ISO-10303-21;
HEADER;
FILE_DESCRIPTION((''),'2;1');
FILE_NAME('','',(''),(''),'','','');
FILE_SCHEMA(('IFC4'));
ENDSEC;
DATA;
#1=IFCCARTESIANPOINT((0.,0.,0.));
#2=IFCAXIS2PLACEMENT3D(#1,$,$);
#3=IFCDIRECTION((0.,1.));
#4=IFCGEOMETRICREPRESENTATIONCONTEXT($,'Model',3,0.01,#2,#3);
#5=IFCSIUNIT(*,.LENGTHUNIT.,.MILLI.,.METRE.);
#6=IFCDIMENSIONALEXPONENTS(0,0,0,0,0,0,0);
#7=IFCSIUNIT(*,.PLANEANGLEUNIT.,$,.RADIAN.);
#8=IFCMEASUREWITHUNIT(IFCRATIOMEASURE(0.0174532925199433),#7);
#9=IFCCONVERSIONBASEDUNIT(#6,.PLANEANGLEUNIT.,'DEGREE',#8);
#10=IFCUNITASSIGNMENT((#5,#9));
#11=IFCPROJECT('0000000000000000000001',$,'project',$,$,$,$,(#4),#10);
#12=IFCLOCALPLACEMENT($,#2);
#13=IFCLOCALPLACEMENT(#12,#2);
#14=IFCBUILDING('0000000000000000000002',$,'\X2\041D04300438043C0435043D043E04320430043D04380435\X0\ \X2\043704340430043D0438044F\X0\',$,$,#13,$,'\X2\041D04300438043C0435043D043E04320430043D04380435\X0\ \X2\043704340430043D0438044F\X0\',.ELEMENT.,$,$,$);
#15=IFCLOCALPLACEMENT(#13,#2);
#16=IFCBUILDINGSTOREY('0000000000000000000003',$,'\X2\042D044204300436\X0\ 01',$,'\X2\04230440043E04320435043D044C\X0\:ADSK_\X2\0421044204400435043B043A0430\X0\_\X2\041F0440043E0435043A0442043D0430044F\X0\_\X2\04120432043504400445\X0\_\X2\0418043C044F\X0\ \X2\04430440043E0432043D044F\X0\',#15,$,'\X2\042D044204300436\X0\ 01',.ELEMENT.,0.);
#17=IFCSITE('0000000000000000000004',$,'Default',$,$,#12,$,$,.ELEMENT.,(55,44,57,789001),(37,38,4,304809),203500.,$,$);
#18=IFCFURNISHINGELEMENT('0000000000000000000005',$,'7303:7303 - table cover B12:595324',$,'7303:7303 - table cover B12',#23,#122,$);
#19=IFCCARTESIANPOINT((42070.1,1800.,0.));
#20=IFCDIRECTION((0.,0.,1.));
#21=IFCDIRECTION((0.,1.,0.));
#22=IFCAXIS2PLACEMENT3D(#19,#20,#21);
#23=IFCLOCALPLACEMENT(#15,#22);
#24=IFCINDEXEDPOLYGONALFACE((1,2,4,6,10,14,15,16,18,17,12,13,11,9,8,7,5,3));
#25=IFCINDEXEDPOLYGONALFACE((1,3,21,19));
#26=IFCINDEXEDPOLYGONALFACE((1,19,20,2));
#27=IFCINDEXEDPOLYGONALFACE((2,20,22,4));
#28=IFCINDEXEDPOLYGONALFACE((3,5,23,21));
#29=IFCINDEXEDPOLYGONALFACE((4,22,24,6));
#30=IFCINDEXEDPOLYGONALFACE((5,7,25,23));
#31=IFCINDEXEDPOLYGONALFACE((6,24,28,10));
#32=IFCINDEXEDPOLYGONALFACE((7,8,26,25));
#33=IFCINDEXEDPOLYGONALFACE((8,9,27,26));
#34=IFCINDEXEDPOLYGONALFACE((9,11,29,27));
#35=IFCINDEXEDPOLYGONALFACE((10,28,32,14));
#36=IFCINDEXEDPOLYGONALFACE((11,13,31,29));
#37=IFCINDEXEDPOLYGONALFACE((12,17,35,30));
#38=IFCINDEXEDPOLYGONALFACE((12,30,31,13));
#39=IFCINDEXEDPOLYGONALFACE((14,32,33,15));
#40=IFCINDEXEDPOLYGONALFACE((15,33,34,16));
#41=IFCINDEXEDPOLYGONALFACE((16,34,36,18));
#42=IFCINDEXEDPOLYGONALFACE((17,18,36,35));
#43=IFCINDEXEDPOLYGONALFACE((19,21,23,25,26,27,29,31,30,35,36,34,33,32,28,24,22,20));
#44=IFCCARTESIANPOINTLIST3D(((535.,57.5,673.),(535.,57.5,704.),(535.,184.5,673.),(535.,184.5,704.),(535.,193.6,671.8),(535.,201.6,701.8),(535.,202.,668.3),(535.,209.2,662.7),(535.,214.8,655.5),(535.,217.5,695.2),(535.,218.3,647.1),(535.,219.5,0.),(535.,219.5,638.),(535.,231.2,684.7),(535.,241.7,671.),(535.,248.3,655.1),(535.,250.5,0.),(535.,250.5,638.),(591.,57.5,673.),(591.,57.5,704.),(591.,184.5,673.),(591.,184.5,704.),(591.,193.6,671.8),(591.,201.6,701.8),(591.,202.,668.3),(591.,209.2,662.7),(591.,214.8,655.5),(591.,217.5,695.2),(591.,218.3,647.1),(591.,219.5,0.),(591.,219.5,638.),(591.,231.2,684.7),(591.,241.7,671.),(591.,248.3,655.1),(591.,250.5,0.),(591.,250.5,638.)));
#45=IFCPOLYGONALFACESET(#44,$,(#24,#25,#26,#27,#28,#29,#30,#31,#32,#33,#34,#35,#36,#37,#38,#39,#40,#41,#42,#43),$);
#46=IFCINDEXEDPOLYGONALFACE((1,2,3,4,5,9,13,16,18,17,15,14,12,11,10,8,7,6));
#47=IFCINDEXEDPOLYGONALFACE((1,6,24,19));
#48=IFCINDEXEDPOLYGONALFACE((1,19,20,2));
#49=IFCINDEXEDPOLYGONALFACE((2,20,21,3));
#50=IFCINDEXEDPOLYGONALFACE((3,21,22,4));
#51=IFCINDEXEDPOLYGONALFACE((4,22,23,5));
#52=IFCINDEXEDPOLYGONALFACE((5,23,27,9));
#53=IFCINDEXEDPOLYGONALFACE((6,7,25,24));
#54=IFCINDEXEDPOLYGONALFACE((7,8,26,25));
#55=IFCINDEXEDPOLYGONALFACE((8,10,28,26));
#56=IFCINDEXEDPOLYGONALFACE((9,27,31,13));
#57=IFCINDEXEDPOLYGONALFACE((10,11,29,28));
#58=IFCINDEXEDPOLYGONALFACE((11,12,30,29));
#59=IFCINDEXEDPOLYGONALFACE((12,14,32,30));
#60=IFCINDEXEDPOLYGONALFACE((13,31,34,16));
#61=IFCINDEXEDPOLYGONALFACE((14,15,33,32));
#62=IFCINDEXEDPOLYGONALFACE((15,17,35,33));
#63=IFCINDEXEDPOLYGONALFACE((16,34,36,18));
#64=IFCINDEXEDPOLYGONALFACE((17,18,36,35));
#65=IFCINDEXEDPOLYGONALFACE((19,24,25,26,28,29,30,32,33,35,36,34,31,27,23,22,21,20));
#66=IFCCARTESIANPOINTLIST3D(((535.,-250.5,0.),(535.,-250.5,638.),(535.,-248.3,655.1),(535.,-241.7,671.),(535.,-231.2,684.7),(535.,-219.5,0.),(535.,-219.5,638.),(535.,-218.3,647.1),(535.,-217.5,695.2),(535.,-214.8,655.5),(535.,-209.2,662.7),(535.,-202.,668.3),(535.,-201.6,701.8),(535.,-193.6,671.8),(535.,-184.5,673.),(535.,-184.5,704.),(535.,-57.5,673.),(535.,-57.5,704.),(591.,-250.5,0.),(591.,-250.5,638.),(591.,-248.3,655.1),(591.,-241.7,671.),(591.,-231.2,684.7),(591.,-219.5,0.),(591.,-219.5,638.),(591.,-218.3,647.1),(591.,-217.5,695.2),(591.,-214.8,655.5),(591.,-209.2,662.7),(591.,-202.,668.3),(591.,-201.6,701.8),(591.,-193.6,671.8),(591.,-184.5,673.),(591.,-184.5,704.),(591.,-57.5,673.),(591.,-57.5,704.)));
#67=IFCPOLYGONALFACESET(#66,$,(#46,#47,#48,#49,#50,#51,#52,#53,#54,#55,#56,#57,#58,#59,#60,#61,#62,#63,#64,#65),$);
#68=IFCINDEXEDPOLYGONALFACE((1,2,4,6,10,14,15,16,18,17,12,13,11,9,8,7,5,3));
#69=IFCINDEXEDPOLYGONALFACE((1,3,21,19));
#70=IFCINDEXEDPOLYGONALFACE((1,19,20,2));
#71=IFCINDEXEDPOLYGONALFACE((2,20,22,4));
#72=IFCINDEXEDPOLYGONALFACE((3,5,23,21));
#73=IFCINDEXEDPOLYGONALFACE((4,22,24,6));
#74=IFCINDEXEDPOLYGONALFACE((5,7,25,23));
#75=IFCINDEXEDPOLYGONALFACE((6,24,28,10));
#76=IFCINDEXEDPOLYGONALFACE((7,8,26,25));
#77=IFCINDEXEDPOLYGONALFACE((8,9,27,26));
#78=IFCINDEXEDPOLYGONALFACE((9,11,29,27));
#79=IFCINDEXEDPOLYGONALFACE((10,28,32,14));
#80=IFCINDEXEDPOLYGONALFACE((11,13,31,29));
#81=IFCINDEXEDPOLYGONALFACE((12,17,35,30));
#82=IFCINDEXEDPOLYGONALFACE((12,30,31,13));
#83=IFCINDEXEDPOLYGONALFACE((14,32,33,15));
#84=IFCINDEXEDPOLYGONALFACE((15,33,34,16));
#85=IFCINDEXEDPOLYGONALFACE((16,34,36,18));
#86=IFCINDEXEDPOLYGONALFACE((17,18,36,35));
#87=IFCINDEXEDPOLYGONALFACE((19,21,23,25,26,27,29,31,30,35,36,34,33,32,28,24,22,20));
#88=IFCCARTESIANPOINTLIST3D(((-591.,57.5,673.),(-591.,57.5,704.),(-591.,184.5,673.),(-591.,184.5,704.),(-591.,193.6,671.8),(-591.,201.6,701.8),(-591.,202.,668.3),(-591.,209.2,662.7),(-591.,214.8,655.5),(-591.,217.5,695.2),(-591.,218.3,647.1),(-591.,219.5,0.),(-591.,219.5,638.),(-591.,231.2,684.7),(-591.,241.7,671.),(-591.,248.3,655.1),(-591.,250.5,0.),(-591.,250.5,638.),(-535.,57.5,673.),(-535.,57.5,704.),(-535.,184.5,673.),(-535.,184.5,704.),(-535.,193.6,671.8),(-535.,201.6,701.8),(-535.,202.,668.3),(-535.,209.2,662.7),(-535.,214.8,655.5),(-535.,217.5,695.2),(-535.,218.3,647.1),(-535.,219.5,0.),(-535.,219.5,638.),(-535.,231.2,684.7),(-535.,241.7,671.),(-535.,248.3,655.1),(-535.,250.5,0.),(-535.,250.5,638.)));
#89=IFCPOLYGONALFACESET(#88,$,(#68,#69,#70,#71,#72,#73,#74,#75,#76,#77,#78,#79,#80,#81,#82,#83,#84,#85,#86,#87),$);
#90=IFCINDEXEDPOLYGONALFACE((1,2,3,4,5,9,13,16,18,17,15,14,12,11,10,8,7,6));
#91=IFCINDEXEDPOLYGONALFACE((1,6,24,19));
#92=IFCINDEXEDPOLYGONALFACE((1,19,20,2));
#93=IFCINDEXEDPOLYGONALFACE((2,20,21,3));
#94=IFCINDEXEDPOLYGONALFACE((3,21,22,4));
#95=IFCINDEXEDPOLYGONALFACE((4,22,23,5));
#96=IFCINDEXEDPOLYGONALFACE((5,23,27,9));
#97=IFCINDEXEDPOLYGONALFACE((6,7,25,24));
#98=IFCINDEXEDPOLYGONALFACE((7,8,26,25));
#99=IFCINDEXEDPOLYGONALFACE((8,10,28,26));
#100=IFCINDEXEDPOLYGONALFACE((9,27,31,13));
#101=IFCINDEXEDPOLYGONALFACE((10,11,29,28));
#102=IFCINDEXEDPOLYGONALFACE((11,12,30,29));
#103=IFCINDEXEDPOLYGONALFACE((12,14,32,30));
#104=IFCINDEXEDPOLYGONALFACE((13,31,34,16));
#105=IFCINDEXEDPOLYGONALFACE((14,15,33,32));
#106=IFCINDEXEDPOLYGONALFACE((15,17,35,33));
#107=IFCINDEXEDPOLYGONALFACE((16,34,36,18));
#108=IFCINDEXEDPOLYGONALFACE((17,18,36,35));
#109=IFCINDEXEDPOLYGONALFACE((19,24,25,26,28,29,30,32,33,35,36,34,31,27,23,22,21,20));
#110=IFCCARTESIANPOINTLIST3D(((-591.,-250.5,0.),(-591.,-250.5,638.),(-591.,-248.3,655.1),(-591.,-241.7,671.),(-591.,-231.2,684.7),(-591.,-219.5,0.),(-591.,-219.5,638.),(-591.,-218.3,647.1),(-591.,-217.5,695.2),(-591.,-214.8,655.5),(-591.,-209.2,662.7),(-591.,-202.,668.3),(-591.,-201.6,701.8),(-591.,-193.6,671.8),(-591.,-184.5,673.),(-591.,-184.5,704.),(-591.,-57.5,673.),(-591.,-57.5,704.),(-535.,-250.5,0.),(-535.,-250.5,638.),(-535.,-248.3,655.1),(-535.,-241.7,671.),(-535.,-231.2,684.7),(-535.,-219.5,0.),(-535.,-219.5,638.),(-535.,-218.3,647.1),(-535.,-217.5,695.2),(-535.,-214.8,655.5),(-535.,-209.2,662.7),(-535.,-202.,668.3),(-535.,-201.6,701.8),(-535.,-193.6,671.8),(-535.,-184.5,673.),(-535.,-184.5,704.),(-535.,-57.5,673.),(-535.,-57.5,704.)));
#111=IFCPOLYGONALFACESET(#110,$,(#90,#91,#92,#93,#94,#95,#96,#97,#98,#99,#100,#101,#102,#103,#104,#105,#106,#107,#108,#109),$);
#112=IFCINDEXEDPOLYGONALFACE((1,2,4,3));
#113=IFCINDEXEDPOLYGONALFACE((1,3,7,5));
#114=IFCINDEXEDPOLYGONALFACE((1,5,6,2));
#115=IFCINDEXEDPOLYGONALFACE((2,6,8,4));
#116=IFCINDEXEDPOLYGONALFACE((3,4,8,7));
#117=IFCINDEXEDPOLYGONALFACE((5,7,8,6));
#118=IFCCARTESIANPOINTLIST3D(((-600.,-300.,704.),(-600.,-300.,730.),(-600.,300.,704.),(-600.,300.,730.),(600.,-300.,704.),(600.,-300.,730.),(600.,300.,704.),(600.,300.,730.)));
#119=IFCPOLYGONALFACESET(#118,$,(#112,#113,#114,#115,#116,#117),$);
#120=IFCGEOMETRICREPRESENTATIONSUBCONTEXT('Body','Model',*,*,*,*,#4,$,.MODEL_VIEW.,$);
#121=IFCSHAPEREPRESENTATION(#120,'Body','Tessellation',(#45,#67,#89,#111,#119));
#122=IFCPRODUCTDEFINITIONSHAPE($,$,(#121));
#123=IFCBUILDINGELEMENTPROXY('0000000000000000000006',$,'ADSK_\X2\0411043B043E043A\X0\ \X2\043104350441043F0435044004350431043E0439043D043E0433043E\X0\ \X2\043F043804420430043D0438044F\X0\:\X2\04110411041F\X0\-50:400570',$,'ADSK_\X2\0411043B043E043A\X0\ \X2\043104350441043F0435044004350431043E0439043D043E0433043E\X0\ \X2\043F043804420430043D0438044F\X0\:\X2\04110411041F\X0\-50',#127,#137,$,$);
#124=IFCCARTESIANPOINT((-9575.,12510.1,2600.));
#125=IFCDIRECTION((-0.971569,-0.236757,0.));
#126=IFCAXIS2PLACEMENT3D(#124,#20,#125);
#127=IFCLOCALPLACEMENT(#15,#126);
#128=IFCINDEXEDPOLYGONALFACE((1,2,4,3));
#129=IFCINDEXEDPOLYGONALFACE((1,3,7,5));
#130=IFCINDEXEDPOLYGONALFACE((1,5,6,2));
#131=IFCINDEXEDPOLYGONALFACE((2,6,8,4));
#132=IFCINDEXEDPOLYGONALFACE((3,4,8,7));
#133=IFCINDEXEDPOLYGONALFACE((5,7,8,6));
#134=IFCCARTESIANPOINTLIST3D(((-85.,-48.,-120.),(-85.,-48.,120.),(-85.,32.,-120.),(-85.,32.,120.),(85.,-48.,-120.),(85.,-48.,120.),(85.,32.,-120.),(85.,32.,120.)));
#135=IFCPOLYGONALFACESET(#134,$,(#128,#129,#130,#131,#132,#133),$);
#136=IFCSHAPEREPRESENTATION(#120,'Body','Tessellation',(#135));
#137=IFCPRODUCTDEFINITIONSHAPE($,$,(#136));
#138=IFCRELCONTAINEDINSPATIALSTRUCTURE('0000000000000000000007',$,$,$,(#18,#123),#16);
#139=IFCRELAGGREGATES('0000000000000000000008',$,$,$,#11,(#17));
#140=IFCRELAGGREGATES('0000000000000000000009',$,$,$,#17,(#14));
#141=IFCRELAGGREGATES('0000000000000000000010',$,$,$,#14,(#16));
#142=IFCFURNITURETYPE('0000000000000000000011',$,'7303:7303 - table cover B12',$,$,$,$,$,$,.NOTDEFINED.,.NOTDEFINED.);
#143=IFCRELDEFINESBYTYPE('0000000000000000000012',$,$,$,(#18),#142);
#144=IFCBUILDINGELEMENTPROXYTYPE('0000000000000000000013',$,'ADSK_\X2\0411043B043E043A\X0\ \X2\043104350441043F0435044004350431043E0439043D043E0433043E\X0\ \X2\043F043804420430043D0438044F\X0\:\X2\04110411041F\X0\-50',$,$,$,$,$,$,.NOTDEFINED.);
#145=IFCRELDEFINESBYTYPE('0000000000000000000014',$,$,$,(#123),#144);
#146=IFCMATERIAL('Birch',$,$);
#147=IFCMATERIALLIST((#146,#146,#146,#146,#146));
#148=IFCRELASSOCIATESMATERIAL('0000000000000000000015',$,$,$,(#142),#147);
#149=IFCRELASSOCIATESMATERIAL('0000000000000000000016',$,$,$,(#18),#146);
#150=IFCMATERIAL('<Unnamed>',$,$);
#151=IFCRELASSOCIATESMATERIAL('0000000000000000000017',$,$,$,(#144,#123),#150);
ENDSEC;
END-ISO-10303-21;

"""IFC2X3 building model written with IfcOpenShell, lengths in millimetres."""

from ifc_helpers import new_model, entity, si_unit, converted_unit, direction, frame, frame_2d, origin, origin_2d_with_axis, place, context, subcontext, project, spatial, polyline, circle_curve, parameter, trimmed, segment, composite_curve, rectangle, outline, extrude, source, transform, mapped, material, material_list, type_object, type_shapes, element, save


model = new_model("IFC2X3")

# Units and contexts
model_context = context("Model", 3, precision=0.01, world=origin(), true_north=direction((0.0, 1.0)))
body_context = subcontext(model_context, "Body", "Model", "MODEL_VIEW")
ifc_project = project(units=[si_unit("LENGTHUNIT", "METRE", prefix="MILLI"), converted_unit("PLANEANGLEUNIT", "DEGREE", entity("IfcRatioMeasure", 0.0174532925199433), si_unit("PLANEANGLEUNIT", "RADIAN"), dimensions=[0, 0, 0, 0, 0, 0, 0])], contexts=[model_context])

# Site, building, storey
site_placement = place(None, origin())
site = spatial("IfcSite", under=ifc_project, at=site_placement, Name="Default", CompositionType="ELEMENT", RefLatitude=(55, 44, 57, 789001), RefLongitude=(37, 38, 4, 304809), RefElevation=203500.0)
building_placement = place(site_placement, origin())
building = spatial("IfcBuilding", under=site, at=building_placement, Name="Наименование здания", LongName="Наименование здания", CompositionType="ELEMENT")
storey_placement = place(building_placement, origin())
storey = spatial("IfcBuildingStorey", under=building, at=storey_placement, Name="Этаж 01", ObjectType="Уровень:ADSK_Стрелка_Проектная_Вверх_Имя уровня", LongName="Этаж 01", CompositionType="ELEMENT", Elevation=0.0)

# Furnishing element
ifc_material_1 = material(Name="Birch")
ifc_material_list_1 = material_list([ifc_material_1, ifc_material_1, ifc_material_1, ifc_material_1, ifc_material_1])
furniture_type = type_object("IfcFurnitureType", Name="7303:7303 - table cover B12", material=ifc_material_list_1)
shared_shape_1 = source(origin(), body_context, "Body", "SweptSolid", [
    extrude(outline(composite_curve([segment(polyline([(-200.2, -120.5), (-169.2, -120.5)]), True, "CONTINUOUS"), segment(polyline([(-169.2, -120.5), (-169.2, 6.5)]), True, "CONTINUOUS"), segment(trimmed(circle_curve(frame_2d((-134.2, 6.5), x_axis=(0.0, -1.0)), 35.0), [parameter(180.0)], [parameter(270.0)], True, "PARAMETER"), False, "CONTINUOUS"), segment(polyline([(-134.2, 41.5), (503.8, 41.5)]), True, "CONTINUOUS"), segment(polyline([(503.8, 41.5), (503.8, 72.5)]), True, "CONTINUOUS"), segment(polyline([(503.8, 72.5), (-134.2, 72.5)]), True, "CONTINUOUS"), segment(trimmed(circle_curve(frame_2d((-134.2, 6.5), x_axis=(0.0, -1.0)), 66.0), [parameter(180.0)], [parameter(270.0)], True, "PARAMETER"), True, "CONTINUOUS"), segment(polyline([(-200.2, 6.5), (-200.2, -120.5)]), True, "CONTINUOUS")], self_intersect=False)), frame((535.0, 178.0, 503.8), z_axis=(1.0, 0.0, 0.0), x_axis=(0.0, 0.0, -1.0)), (0.0, 0.0, 1.0), 56.0),
    extrude(outline(composite_curve([segment(polyline([(-120.5, -200.2), (6.5, -200.2)]), True, "CONTINUOUS"), segment(trimmed(circle_curve(frame_2d((6.5, -134.2), x_axis=(-1.0, 0.0)), 66.0), [parameter(90.0)], [parameter(180.0)], True, "PARAMETER"), True, "CONTINUOUS"), segment(polyline([(72.5, -134.2), (72.5, 503.8)]), True, "CONTINUOUS"), segment(polyline([(72.5, 503.8), (41.5, 503.8)]), True, "CONTINUOUS"), segment(polyline([(41.5, 503.8), (41.5, -134.2)]), True, "CONTINUOUS"), segment(trimmed(circle_curve(frame_2d((6.5, -134.2), x_axis=(-1.0, 0.0)), 35.0), [parameter(90.0)], [parameter(180.0)], True, "PARAMETER"), False, "CONTINUOUS"), segment(polyline([(6.5, -169.2), (-120.5, -169.2)]), True, "CONTINUOUS"), segment(polyline([(-120.5, -169.2), (-120.5, -200.2)]), True, "CONTINUOUS")], self_intersect=False)), frame((535.0, -178.0, 503.8), z_axis=(1.0, 0.0, 0.0), x_axis=(0.0, -1.0, 0.0)), (0.0, 0.0, 1.0), 56.0),
    extrude(outline(composite_curve([segment(polyline([(-200.2, -120.5), (-169.2, -120.5)]), True, "CONTINUOUS"), segment(polyline([(-169.2, -120.5), (-169.2, 6.5)]), True, "CONTINUOUS"), segment(trimmed(circle_curve(frame_2d((-134.2, 6.5), x_axis=(0.0, -1.0)), 35.0), [parameter(180.0)], [parameter(270.0)], True, "PARAMETER"), False, "CONTINUOUS"), segment(polyline([(-134.2, 41.5), (503.8, 41.5)]), True, "CONTINUOUS"), segment(polyline([(503.8, 41.5), (503.8, 72.5)]), True, "CONTINUOUS"), segment(polyline([(503.8, 72.5), (-134.2, 72.5)]), True, "CONTINUOUS"), segment(trimmed(circle_curve(frame_2d((-134.2, 6.5), x_axis=(0.0, -1.0)), 66.0), [parameter(180.0)], [parameter(270.0)], True, "PARAMETER"), True, "CONTINUOUS"), segment(polyline([(-200.2, 6.5), (-200.2, -120.5)]), True, "CONTINUOUS")], self_intersect=False)), frame((-591.0, 178.0, 503.8), z_axis=(1.0, 0.0, 0.0), x_axis=(0.0, 0.0, -1.0)), (0.0, 0.0, 1.0), 56.0),
    extrude(outline(composite_curve([segment(polyline([(-120.5, -200.2), (6.5, -200.2)]), True, "CONTINUOUS"), segment(trimmed(circle_curve(frame_2d((6.5, -134.2), x_axis=(-1.0, 0.0)), 66.0), [parameter(90.0)], [parameter(180.0)], True, "PARAMETER"), True, "CONTINUOUS"), segment(polyline([(72.5, -134.2), (72.5, 503.8)]), True, "CONTINUOUS"), segment(polyline([(72.5, 503.8), (41.5, 503.8)]), True, "CONTINUOUS"), segment(polyline([(41.5, 503.8), (41.5, -134.2)]), True, "CONTINUOUS"), segment(trimmed(circle_curve(frame_2d((6.5, -134.2), x_axis=(-1.0, 0.0)), 35.0), [parameter(90.0)], [parameter(180.0)], True, "PARAMETER"), False, "CONTINUOUS"), segment(polyline([(6.5, -169.2), (-120.5, -169.2)]), True, "CONTINUOUS"), segment(polyline([(-120.5, -169.2), (-120.5, -200.2)]), True, "CONTINUOUS")], self_intersect=False)), frame((-591.0, -178.0, 503.8), z_axis=(1.0, 0.0, 0.0), x_axis=(0.0, -1.0, 0.0)), (0.0, 0.0, 1.0), 56.0),
    extrude(rectangle(XDim=1200.0, YDim=600.0, at=origin_2d_with_axis()), frame((0.0, 0.0, 704.0), z_axis=(0.0, 0.0, 1.0), x_axis=(-1.0, 0.0, 0.0)), (0.0, 0.0, 1.0), 26.0),
])
type_shapes(furniture_type, [shared_shape_1])
for number, where, z_axis, x_axis, name in (
    (1, (42070.1, 1800.0, 0.0), (0.0, 0.0, 1.0), (0.0, 1.0, 0.0), "7303:7303 - table cover B12:595324"),
):
    element("IfcFurnishingElement", number, at=place(storey_placement, frame(where, z_axis=z_axis, x_axis=x_axis)), inside=storey, type_object=furniture_type, material=ifc_material_1, Name=name, ObjectType="7303:7303 - table cover B12", context=body_context, shape_type="MappedRepresentation", body=[
        mapped(shared_shape_1, transform((0.0, 0.0, 0.0), scale=1.0)),
    ])

# Building element proxy
ifc_material_2 = material(Name="<Unnamed>")
building_element_proxy_type_1 = type_object("IfcBuildingElementProxyType", Name="ADSK_Блок бесперебойного питания:ББП-50", PredefinedType="NOTDEFINED", material=ifc_material_2)
shared_shape_2 = source(origin(), body_context, "Body", "SweptSolid", [
    extrude(rectangle(XDim=170.0, YDim=80.0, at=origin_2d_with_axis()), frame((0.0, -8.0, -120.0), z_axis=(0.0, 0.0, 1.0), x_axis=(-1.0, 0.0, 0.0)), (0.0, 0.0, 1.0), 240.0),
])
type_shapes(building_element_proxy_type_1, [shared_shape_2])
proxy_1_placement = place(storey_placement, frame((-9575.0, 12510.1, 2600.0), z_axis=(0.0, 0.0, 1.0), x_axis=(-0.971569, -0.236757, 0.0)))
element("IfcBuildingElementProxy", 2, at=proxy_1_placement, inside=storey, type_object=building_element_proxy_type_1, material=ifc_material_2, Name="ADSK_Блок бесперебойного питания:ББП-50:400570", ObjectType="ADSK_Блок бесперебойного питания:ББП-50", context=body_context, shape_type="MappedRepresentation", body=[
    mapped(shared_shape_2, transform((0.0, 0.0, 0.0), scale=1.0)),
])

save(model, "model.ifc")
